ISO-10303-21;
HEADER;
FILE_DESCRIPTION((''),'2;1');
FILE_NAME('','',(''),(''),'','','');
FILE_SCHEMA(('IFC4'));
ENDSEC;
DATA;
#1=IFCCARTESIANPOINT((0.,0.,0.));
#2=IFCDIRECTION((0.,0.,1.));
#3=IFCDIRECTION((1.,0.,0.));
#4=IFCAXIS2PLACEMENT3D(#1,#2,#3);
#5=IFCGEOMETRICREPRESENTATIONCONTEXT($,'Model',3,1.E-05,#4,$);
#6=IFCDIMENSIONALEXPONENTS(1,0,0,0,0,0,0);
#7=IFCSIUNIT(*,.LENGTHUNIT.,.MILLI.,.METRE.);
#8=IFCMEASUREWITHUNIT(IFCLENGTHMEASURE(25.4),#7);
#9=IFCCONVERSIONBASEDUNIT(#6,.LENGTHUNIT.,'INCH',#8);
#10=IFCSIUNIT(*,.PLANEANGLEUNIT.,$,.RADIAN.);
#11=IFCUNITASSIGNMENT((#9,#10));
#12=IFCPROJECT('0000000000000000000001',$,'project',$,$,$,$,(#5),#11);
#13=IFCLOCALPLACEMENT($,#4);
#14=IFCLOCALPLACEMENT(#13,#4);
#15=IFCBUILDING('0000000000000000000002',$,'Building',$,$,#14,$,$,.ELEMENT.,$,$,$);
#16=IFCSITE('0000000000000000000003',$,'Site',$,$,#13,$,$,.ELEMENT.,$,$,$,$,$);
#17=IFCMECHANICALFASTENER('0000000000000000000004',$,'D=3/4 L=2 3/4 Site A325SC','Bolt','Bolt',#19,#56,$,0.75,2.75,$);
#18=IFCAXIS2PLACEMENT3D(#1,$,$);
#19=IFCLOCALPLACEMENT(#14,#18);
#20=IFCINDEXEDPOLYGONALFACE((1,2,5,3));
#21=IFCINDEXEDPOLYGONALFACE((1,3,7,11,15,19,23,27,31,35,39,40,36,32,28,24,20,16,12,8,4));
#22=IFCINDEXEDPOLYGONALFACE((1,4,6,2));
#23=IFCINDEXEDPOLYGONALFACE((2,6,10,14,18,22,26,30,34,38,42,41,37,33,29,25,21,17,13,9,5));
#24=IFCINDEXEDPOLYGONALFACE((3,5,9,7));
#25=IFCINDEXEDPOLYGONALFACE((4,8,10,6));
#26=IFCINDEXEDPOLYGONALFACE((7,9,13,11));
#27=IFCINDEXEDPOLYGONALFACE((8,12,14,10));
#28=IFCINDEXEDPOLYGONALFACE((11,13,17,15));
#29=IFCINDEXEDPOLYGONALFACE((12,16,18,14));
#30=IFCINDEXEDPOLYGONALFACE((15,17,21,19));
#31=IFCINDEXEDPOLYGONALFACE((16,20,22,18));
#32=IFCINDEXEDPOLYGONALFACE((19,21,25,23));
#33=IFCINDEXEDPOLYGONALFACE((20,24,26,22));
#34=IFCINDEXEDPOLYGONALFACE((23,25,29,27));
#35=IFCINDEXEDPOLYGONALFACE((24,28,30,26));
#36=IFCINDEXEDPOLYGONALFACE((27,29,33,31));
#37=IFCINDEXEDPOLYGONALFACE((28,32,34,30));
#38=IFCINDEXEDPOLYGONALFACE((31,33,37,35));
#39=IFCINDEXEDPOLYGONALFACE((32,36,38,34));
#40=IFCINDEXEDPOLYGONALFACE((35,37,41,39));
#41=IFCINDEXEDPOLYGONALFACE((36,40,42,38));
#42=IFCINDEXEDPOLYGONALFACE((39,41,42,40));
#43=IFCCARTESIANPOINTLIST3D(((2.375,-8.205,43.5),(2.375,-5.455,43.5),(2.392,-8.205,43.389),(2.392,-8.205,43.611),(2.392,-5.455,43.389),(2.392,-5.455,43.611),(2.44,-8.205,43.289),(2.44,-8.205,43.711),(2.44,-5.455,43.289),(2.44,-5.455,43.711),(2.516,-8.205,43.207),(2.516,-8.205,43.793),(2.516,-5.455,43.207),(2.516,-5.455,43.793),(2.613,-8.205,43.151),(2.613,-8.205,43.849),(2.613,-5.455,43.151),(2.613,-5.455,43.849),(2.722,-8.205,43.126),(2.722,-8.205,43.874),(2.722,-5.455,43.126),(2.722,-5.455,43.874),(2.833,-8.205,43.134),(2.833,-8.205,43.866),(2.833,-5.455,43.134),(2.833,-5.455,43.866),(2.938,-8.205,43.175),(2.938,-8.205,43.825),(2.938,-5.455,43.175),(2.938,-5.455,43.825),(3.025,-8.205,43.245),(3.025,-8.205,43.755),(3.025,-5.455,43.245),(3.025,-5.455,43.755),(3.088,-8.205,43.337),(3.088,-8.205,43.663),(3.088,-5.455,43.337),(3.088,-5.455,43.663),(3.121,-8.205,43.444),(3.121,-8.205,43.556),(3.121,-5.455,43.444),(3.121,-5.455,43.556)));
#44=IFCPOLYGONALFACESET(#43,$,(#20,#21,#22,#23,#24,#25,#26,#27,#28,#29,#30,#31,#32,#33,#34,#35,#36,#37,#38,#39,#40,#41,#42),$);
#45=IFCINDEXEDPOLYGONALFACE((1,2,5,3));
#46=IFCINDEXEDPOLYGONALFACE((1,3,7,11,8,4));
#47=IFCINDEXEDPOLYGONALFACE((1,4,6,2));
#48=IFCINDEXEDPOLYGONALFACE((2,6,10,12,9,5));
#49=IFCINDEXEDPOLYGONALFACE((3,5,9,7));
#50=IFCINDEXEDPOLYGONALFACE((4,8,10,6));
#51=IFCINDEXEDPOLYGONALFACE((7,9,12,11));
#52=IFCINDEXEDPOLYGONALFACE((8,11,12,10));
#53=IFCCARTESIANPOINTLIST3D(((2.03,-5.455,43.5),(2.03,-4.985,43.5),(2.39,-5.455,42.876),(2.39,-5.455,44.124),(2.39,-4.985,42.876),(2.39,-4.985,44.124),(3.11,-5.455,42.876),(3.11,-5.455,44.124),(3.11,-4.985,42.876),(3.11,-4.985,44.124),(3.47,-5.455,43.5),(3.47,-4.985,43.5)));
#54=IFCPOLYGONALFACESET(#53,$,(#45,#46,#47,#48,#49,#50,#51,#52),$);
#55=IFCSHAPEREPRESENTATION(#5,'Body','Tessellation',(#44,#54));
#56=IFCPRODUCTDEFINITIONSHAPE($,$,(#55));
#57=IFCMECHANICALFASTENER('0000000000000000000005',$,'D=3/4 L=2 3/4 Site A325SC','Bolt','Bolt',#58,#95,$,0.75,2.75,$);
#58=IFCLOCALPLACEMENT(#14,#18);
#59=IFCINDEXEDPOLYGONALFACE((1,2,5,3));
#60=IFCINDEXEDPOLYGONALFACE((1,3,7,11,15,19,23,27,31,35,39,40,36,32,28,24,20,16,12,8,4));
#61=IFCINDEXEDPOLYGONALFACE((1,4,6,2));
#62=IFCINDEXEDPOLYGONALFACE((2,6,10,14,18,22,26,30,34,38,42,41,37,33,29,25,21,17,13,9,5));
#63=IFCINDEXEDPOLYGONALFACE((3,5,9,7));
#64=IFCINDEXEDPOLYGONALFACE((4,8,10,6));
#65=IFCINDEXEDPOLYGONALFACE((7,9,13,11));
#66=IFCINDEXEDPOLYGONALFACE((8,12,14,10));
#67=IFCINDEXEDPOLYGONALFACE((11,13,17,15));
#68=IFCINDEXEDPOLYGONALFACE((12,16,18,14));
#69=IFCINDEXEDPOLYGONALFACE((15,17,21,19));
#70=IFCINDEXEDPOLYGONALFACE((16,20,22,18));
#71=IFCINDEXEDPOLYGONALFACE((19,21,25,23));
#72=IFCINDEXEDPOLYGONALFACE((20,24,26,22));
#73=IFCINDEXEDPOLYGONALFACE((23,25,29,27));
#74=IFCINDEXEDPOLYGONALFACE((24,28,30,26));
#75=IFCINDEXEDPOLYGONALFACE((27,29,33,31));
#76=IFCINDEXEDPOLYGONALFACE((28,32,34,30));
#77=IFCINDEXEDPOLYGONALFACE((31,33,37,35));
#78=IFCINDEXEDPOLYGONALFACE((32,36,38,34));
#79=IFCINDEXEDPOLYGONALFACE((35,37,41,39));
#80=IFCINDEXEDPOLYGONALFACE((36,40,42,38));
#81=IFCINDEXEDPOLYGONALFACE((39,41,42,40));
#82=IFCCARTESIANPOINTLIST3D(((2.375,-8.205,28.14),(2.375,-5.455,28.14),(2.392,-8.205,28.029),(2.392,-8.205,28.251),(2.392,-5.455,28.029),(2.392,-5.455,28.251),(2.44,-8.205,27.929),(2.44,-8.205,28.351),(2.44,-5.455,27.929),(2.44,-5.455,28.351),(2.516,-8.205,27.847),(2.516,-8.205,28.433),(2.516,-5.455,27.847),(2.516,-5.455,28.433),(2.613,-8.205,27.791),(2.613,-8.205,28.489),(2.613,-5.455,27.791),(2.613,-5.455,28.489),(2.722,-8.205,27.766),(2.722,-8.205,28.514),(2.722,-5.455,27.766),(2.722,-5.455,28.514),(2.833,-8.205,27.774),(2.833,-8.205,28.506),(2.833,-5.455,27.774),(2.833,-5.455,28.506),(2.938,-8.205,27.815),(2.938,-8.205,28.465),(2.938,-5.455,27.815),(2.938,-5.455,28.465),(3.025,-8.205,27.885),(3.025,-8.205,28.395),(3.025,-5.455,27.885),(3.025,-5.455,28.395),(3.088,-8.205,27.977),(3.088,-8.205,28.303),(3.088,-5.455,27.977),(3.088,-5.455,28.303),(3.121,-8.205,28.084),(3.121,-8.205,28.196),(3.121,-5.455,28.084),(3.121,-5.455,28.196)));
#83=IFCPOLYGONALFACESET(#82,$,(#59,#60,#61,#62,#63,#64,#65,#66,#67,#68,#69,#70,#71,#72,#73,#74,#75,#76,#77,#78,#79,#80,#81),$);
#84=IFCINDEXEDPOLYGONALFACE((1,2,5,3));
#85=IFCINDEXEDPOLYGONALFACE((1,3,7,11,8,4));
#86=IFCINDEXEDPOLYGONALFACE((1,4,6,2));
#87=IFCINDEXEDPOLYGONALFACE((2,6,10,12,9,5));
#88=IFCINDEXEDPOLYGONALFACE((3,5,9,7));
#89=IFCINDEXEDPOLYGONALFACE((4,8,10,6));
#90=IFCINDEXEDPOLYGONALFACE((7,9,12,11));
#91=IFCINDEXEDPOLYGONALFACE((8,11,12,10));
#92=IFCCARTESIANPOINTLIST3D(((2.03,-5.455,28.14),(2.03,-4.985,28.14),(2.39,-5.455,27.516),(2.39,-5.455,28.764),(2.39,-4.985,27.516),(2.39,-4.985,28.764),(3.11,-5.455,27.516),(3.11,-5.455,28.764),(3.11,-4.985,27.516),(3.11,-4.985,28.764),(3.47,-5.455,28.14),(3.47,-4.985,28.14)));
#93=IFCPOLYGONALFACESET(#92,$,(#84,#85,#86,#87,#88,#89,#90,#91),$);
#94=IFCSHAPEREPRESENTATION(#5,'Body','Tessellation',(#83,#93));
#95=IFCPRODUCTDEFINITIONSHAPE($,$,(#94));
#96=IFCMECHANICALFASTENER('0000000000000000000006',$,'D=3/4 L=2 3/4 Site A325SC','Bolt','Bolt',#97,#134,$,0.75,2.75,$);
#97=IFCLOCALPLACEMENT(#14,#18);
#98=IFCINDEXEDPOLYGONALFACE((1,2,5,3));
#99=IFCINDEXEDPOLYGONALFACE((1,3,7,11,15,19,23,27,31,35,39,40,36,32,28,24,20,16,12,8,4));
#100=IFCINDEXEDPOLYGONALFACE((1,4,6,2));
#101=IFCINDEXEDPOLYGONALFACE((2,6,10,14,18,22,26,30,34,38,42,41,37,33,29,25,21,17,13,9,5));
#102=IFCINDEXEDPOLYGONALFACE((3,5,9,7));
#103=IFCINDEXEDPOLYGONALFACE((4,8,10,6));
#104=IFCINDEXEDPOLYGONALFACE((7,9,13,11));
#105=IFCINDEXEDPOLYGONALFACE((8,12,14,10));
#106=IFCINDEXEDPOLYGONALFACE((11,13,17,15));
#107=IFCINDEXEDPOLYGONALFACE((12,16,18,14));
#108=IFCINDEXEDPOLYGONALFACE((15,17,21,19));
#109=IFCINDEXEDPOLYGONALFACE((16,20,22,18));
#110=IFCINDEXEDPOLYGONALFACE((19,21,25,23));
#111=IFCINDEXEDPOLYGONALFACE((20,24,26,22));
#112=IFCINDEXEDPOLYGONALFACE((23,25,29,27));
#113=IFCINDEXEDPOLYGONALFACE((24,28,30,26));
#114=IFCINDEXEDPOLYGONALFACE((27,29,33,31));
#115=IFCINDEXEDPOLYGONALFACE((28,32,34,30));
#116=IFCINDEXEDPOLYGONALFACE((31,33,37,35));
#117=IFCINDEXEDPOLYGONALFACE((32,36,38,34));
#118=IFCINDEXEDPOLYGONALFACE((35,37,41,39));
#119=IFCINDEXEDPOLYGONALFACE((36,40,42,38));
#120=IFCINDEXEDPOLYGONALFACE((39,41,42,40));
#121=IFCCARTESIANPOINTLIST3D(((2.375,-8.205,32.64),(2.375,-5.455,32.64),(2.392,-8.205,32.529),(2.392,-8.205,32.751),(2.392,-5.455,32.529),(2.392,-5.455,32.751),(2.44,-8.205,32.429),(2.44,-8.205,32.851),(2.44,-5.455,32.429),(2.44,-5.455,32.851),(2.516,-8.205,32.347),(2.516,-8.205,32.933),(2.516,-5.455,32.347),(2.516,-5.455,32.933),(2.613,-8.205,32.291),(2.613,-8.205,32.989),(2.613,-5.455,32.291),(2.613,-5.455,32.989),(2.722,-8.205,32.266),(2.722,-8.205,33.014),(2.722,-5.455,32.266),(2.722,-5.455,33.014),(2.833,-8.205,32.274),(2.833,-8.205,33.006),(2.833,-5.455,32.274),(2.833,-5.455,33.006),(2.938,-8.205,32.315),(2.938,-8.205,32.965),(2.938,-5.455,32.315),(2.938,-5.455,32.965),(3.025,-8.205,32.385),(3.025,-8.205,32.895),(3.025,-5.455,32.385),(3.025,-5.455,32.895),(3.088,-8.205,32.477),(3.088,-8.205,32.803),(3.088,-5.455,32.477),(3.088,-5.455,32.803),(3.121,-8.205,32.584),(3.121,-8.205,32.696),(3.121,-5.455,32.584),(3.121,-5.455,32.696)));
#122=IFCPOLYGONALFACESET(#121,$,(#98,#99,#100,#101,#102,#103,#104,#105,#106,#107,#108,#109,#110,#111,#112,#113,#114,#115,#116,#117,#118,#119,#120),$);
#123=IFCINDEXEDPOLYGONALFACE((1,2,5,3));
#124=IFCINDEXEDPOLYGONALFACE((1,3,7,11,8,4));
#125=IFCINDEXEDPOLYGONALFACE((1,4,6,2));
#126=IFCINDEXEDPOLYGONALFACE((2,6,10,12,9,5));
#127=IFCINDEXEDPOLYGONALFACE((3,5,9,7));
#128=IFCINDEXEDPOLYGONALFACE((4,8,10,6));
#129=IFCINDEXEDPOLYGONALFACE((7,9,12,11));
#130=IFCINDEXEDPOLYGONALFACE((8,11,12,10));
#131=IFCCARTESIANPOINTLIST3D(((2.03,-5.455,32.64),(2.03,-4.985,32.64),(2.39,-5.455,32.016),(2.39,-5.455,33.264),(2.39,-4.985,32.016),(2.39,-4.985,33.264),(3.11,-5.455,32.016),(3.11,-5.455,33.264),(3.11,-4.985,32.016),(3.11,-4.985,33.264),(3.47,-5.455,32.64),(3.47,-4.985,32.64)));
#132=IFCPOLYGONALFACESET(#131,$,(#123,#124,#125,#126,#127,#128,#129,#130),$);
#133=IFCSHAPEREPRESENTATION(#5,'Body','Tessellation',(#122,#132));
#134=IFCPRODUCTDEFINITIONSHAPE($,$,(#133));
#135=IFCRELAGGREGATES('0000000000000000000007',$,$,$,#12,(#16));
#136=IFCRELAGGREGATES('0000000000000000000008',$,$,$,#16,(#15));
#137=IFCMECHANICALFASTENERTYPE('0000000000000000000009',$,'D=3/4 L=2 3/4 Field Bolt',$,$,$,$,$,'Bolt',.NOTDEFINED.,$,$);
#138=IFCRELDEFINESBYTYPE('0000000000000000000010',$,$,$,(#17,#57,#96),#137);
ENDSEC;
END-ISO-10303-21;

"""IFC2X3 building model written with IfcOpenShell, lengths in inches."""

from ifc_helpers import new_model, entity, si_unit, converted_unit, frame, origin_with_axes, origin_2d_with_axis, place, context, project, spatial, polyline, circle, outline, extrude, source, transform, mapped, type_object, type_shapes, element, save


model = new_model("IFC2X3")

# Units and contexts
model_context = context("Model", 3, precision=1e-05, world=origin_with_axes())
ifc_project = project(units=[converted_unit("LENGTHUNIT", "INCH", entity("IfcLengthMeasure", 25.4), si_unit("LENGTHUNIT", "METRE", prefix="MILLI"), dimensions=[1, 0, 0, 0, 0, 0, 0]), si_unit("PLANEANGLEUNIT", "RADIAN")], contexts=[model_context])

# Site, building
site_placement = place(None, origin_with_axes())
site = spatial("IfcSite", under=ifc_project, at=site_placement, Name="Site", CompositionType="ELEMENT")
building_placement = place(site_placement, origin_with_axes())
building = spatial("IfcBuilding", under=site, at=building_placement, Name="Building", CompositionType="ELEMENT")

# Mechanical fasteners
placement_1 = place(building_placement, frame((0.0, 0.0, 46.0), z_axis=(0.0, 0.0, 1.0), x_axis=(0.0, -1.0, 0.0)))
mechanical_fastener_type_1 = type_object("IfcMechanicalFastenerType", Name="D=3/4 L=2 3/4 Field Bolt", ElementType="Bolt")
shared_shape_1 = source(origin_with_axes(), model_context, "Body", "SweptSolid", [
    extrude(circle(Radius=0.375, at=origin_2d_with_axis()), frame((0.0, 0.0, 0.0), z_axis=(1.0, 0.0, 0.0), x_axis=(0.0, 1.0, 0.0)), (0.0, 0.0, 1.0), 2.75),
    extrude(outline(polyline([(-0.72, 0.0), (-0.36, 0.624), (0.36, 0.624), (0.72, 0.0), (0.36, -0.624), (-0.36, -0.624), (-0.72, 0.0)])), frame((0.0, 0.0, 0.0), z_axis=(1.0, 0.0, 0.0), x_axis=(0.0, 1.0, 0.0)), (0.0, 0.0, -1.0), 0.47),
])
type_shapes(mechanical_fastener_type_1, [shared_shape_1])
placement_2 = place(placement_1, frame((5.455, -2.75, 2.0), z_axis=(0.0, 0.0, -1.0), x_axis=(1.0, 0.0, 0.0)))
for number, where, z_axis, x_axis, name in (
    (1, (0.0, -5.5, 4.5), (0.0, 0.0, 1.0), (1.0, 0.0, 0.0), "D=3/4 L=2 3/4 Site A325SC"),
    (2, (0.0, -5.5, 19.86), (0.0, 0.0, 1.0), (1.0, 0.0, 0.0), "D=3/4 L=2 3/4 Site A325SC"),
    (3, (0.0, -5.5, 15.36), (0.0, 0.0, 1.0), (1.0, 0.0, 0.0), "D=3/4 L=2 3/4 Site A325SC"),
):
    element("IfcMechanicalFastener", number, at=place(placement_2, frame(where, z_axis=z_axis, x_axis=x_axis)), type_object=mechanical_fastener_type_1, Name=name, Description="Bolt", ObjectType="Bolt", NominalDiameter=0.75, NominalLength=2.75, context=model_context, shape_type="MappedRepresentation", body=[
        mapped(shared_shape_1, transform((0.0, 0.0, 0.0), scale=1.0)),
    ])

save(model, "model.ifc")
